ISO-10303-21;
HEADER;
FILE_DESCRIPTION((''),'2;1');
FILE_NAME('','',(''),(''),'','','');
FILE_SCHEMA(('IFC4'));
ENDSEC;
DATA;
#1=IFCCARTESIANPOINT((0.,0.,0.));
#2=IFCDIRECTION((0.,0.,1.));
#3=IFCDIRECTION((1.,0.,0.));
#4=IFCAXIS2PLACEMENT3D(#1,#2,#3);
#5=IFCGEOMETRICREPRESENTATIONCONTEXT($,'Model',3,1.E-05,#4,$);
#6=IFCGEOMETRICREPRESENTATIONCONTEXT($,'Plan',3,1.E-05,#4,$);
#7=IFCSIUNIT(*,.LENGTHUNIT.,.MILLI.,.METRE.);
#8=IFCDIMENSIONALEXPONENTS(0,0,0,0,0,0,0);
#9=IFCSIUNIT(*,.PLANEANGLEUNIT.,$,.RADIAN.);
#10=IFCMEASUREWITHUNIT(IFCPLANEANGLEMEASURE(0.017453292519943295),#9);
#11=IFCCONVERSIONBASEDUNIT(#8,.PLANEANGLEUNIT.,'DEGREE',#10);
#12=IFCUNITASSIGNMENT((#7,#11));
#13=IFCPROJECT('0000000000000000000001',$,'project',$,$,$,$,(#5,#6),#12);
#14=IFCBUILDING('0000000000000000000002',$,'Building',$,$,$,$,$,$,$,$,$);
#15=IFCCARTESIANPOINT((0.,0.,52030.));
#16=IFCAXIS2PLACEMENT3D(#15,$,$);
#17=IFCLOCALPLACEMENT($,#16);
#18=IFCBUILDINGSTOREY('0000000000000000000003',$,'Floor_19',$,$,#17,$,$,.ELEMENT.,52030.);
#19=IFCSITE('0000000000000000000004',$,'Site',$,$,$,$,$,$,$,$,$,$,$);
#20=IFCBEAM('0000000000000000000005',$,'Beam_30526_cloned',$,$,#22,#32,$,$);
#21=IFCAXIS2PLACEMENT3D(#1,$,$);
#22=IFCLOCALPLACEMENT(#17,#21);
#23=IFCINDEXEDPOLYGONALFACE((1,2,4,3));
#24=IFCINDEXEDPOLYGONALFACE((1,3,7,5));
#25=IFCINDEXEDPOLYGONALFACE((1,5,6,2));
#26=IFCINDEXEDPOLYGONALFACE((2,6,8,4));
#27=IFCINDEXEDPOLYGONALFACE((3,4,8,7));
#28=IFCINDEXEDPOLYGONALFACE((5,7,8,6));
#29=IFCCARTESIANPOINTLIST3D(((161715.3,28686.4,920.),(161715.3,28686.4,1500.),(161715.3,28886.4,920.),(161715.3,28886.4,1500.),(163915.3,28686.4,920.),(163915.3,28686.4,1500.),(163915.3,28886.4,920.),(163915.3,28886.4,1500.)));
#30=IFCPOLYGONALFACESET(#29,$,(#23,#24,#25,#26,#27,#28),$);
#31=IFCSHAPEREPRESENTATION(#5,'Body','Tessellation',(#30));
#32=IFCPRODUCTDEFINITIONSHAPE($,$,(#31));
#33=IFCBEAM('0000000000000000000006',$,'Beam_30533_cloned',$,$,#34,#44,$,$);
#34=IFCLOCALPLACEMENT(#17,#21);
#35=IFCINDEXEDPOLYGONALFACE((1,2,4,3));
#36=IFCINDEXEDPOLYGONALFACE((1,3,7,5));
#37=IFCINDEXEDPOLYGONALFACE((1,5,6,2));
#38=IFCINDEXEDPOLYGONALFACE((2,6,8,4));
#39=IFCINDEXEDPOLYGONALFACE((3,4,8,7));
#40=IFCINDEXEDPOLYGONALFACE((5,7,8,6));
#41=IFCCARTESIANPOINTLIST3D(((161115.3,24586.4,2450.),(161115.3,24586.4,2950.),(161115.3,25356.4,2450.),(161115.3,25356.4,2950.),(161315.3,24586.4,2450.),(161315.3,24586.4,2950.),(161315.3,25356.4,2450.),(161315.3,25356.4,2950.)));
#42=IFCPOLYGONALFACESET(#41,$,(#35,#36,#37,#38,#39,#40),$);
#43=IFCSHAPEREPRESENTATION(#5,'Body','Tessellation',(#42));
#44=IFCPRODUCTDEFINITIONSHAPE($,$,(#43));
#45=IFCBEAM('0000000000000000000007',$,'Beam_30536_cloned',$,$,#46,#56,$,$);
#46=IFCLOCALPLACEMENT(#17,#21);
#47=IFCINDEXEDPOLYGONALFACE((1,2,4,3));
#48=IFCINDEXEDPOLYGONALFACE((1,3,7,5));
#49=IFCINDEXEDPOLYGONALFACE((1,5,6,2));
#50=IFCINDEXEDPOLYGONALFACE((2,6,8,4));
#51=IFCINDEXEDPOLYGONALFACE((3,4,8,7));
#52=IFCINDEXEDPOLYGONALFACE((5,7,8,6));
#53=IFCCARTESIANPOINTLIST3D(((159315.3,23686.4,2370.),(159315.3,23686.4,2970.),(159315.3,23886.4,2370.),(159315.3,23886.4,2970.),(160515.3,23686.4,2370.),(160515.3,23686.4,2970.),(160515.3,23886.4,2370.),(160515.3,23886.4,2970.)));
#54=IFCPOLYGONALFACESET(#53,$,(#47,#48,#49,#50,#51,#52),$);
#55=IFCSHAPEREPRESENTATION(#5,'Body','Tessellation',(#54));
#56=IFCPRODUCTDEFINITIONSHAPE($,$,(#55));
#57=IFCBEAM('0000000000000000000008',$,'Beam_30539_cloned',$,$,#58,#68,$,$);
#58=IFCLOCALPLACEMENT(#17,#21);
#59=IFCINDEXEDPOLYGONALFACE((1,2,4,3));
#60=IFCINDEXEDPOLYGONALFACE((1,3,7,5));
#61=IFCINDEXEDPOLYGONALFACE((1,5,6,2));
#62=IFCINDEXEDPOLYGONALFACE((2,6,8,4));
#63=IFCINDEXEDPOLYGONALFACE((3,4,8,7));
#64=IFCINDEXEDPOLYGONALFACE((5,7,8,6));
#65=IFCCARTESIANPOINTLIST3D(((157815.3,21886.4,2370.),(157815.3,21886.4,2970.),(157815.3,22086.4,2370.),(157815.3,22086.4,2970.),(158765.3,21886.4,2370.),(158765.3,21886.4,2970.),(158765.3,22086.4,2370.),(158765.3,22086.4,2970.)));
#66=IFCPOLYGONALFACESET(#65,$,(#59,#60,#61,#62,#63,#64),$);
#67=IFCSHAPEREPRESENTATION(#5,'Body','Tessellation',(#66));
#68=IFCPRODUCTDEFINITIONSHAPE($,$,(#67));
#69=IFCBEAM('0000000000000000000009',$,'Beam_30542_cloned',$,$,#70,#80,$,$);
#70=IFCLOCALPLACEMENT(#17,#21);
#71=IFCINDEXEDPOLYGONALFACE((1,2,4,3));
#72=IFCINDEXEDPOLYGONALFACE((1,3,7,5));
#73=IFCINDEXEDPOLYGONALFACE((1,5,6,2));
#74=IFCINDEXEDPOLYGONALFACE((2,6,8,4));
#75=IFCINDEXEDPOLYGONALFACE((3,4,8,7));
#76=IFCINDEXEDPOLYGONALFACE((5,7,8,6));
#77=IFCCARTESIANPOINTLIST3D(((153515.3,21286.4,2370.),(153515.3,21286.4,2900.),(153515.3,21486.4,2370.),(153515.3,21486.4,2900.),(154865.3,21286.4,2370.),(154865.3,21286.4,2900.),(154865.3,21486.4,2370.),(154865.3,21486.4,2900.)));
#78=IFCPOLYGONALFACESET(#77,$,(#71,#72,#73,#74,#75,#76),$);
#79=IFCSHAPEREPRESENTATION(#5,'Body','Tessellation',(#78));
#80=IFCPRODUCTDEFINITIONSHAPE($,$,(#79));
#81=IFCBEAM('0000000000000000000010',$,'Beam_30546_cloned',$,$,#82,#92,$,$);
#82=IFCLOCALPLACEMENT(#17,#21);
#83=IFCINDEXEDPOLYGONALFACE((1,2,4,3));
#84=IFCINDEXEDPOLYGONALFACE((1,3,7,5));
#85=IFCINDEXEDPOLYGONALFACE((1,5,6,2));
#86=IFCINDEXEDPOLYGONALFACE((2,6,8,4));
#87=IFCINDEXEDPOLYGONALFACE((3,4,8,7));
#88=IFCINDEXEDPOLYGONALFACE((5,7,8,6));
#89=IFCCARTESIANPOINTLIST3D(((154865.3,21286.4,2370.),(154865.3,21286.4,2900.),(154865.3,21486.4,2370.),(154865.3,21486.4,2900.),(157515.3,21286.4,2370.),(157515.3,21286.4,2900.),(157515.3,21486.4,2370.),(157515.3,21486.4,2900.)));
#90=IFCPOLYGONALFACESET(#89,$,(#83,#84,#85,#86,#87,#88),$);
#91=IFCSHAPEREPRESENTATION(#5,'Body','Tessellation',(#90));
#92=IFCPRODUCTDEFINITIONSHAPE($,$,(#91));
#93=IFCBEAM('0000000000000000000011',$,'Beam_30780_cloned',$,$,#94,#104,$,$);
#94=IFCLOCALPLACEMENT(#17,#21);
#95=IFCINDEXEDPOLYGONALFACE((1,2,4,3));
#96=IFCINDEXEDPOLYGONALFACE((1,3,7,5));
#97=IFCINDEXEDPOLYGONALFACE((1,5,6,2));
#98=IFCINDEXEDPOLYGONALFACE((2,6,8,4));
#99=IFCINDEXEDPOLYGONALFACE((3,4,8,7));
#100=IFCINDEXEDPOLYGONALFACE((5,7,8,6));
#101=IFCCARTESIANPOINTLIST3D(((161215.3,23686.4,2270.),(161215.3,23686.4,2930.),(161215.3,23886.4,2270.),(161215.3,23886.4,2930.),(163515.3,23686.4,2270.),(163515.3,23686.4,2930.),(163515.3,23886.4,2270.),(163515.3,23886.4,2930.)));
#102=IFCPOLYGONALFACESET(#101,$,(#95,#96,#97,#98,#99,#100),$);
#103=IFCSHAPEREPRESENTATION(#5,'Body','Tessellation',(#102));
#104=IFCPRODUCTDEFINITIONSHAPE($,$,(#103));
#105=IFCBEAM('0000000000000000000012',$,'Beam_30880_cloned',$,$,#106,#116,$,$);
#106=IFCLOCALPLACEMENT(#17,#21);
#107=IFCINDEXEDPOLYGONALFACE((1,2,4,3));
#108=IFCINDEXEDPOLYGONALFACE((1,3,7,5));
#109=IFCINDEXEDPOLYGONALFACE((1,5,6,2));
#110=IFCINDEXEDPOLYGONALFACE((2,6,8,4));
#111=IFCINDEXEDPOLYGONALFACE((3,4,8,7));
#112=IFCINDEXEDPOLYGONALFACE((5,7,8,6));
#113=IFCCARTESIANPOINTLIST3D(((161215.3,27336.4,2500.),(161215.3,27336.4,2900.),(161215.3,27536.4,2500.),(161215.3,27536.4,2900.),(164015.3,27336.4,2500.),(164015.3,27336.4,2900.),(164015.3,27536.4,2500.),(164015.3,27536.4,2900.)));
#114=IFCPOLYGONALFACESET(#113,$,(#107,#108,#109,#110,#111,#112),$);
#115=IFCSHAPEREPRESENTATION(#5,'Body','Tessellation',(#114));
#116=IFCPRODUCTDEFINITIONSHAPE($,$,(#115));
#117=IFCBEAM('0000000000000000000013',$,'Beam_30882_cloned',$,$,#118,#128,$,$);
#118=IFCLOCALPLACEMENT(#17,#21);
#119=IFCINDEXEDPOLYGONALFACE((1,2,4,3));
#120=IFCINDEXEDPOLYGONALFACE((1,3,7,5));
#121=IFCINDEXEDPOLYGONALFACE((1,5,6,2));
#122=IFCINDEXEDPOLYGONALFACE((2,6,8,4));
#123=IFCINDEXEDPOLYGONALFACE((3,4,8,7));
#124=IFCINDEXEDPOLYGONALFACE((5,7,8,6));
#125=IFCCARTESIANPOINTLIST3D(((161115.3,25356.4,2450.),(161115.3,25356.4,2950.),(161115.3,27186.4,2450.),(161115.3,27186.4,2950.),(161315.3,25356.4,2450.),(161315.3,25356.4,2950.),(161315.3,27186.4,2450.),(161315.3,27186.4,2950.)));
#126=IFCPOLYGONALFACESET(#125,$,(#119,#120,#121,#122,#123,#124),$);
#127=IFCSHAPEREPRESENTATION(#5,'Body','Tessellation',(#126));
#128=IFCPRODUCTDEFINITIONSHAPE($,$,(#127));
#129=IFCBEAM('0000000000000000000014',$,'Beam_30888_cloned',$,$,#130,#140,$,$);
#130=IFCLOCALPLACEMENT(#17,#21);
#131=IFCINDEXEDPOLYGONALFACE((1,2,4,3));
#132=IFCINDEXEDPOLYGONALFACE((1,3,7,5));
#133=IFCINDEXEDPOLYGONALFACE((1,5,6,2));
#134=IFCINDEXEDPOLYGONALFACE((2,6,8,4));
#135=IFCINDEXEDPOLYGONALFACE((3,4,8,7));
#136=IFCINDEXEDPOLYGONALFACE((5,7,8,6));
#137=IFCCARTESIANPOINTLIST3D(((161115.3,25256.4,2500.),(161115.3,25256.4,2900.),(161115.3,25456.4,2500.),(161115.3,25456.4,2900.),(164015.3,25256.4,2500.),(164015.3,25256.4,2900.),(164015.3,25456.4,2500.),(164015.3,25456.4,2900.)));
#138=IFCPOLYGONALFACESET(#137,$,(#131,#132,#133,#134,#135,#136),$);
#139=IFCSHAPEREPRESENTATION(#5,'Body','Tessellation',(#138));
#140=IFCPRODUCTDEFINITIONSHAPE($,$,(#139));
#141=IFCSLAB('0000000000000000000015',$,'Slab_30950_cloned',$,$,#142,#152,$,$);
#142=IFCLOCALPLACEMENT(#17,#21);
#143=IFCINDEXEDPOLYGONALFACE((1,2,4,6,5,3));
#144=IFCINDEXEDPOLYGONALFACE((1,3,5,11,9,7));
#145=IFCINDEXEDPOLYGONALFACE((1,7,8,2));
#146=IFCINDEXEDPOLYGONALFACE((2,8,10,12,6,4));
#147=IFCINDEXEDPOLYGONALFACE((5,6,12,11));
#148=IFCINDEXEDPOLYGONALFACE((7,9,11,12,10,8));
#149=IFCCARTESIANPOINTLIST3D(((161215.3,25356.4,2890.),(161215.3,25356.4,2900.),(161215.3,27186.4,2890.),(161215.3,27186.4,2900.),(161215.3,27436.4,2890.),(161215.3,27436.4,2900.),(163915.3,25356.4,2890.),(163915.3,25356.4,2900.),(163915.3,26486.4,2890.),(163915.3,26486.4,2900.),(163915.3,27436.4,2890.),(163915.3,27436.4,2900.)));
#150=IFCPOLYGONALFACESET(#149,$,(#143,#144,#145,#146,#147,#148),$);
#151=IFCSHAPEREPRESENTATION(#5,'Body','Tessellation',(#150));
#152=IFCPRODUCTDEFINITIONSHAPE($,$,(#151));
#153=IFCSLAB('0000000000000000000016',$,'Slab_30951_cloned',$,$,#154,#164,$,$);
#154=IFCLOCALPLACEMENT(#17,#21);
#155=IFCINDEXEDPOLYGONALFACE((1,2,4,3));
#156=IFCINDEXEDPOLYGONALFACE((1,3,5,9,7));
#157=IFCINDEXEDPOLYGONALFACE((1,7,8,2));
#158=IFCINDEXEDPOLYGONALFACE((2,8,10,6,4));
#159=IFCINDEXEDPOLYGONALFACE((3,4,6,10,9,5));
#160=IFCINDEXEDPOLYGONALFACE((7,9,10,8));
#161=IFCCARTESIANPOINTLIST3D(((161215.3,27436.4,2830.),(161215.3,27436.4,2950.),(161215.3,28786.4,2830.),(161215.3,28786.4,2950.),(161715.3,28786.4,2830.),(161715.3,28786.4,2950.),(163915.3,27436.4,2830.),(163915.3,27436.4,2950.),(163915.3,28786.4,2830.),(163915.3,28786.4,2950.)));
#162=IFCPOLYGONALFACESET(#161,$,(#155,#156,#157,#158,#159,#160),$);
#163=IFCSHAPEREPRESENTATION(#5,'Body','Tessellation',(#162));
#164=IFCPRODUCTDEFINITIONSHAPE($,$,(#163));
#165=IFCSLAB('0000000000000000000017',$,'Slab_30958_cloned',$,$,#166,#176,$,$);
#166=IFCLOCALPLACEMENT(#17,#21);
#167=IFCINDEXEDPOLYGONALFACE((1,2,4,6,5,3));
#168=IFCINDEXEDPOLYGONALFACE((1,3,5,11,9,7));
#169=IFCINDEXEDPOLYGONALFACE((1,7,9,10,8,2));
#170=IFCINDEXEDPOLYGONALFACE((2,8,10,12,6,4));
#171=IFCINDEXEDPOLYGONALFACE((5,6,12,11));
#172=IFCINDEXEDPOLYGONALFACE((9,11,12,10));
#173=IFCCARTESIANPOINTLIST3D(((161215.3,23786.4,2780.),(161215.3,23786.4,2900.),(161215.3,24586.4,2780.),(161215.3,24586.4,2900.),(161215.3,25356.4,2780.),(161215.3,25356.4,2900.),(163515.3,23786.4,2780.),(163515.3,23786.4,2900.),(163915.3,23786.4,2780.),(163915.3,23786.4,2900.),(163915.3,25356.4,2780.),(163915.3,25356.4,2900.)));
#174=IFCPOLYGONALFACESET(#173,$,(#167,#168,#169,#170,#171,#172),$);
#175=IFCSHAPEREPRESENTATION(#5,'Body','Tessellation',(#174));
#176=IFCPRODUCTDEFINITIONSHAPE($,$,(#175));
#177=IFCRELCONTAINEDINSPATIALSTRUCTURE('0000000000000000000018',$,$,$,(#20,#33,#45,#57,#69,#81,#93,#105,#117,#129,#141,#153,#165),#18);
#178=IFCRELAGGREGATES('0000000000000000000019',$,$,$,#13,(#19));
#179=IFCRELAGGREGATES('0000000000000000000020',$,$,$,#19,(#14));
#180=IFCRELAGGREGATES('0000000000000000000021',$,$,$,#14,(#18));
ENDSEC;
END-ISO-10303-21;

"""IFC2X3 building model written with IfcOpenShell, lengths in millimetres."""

from ifc_helpers import new_model, entity, si_unit, converted_unit, frame, origin_with_axes, origin_2d, place, context, project, spatial, polyline, rectangle, outline, extrude, source, transform, mapped, element, save


model = new_model("IFC2X3")

# Units and contexts
model_context = context("Model", 3, precision=1e-05, world=origin_with_axes())
plan_context = context("Plan", 3, precision=1e-05, world=origin_with_axes())
ifc_project = project(units=[si_unit("LENGTHUNIT", "METRE", prefix="MILLI"), converted_unit("PLANEANGLEUNIT", "DEGREE", entity("IfcPlaneAngleMeasure", 0.017453292519943295), si_unit("PLANEANGLEUNIT", "RADIAN"), dimensions=[0, 0, 0, 0, 0, 0, 0])], contexts=[model_context, plan_context])

# Site, building, storey
site = spatial("IfcSite", under=ifc_project, Name="Site")
building = spatial("IfcBuilding", under=site, Name="Building")
storey_placement = place(None, frame((0.0, 0.0, 52030.0)))
storey = spatial("IfcBuildingStorey", under=building, at=storey_placement, Name="Floor_19", CompositionType="ELEMENT", Elevation=52030.0)

# Beams
shared_shape_1 = source(origin_with_axes(), model_context, "Body", "SweptSolid", [
    extrude(rectangle(XDim=200.0, YDim=580.0, at=origin_2d()), origin_with_axes(), (0.0, 0.0, 1.0), 2200.0),
])
beam_1_placement = place(storey_placement, frame((161715.3, 28786.4, 1210.0), z_axis=(2200.0, 0.0, 0.0), x_axis=(0.0, -2200.0, 0.0)))
element("IfcBeam", 1, at=beam_1_placement, inside=storey, Name="Beam_30526_cloned", context=model_context, shape_type="MappedRepresentation", body=[
    mapped(shared_shape_1, transform((0.0, 0.0, 0.0), x_axis=(1.0, 0.0, 0.0), y_axis=(0.0, 1.0, 0.0), z_axis=(0.0, 0.0, 1.0), scale=1.0)),
])
shared_shape_2 = source(origin_with_axes(), model_context, "Body", "SweptSolid", [
    extrude(rectangle(XDim=200.0, YDim=500.0, at=origin_2d()), origin_with_axes(), (0.0, 0.0, 1.0), 770.0),
])
beam_2_placement = place(storey_placement, frame((161215.3, 24586.4, 2700.0), z_axis=(-0.00002, 769.999996, 0.0), x_axis=(769.999996, 0.00002, 0.0)))
element("IfcBeam", 2, at=beam_2_placement, inside=storey, Name="Beam_30533_cloned", context=model_context, shape_type="MappedRepresentation", body=[
    mapped(shared_shape_2, transform((0.0, 0.0, 0.0), x_axis=(1.0, 0.0, 0.0), y_axis=(0.0, 1.0, 0.0), z_axis=(0.0, 0.0, 1.0), scale=1.0)),
])
shared_shape_3 = source(origin_with_axes(), model_context, "Body", "SweptSolid", [
    extrude(rectangle(XDim=200.0, YDim=600.0, at=origin_2d()), origin_with_axes(), (0.0, 0.0, 1.0), 1200.0),
])
beam_3_placement = place(storey_placement, frame((159315.3, 23786.4, 2670.0), z_axis=(1200.0, 0.0, 0.0), x_axis=(0.0, -1200.0, 0.0)))
element("IfcBeam", 3, at=beam_3_placement, inside=storey, Name="Beam_30536_cloned", context=model_context, shape_type="MappedRepresentation", body=[
    mapped(shared_shape_3, transform((0.0, 0.0, 0.0), x_axis=(1.0, 0.0, 0.0), y_axis=(0.0, 1.0, 0.0), z_axis=(0.0, 0.0, 1.0), scale=1.0)),
])
shared_shape_4 = source(origin_with_axes(), model_context, "Body", "SweptSolid", [
    extrude(rectangle(XDim=200.0, YDim=600.0, at=origin_2d()), origin_with_axes(), (0.0, 0.0, 1.0), 950.0),
])
beam_4_placement = place(storey_placement, frame((157815.3, 21986.4, 2670.0), z_axis=(950.0, 0.0, 0.0), x_axis=(0.0, -950.0, 0.0)))
element("IfcBeam", 4, at=beam_4_placement, inside=storey, Name="Beam_30539_cloned", context=model_context, shape_type="MappedRepresentation", body=[
    mapped(shared_shape_4, transform((0.0, 0.0, 0.0), x_axis=(1.0, 0.0, 0.0), y_axis=(0.0, 1.0, 0.0), z_axis=(0.0, 0.0, 1.0), scale=1.0)),
])
shared_shape_5 = source(origin_with_axes(), model_context, "Body", "SweptSolid", [
    extrude(rectangle(XDim=200.0, YDim=530.0, at=origin_2d()), origin_with_axes(), (0.0, 0.0, 1.0), 1350.0),
])
beam_5_placement = place(storey_placement, frame((153515.3, 21386.4, 2635.0), z_axis=(1350.0, 0.0, 0.0), x_axis=(0.0, -1350.0, 0.0)))
element("IfcBeam", 5, at=beam_5_placement, inside=storey, Name="Beam_30542_cloned", context=model_context, shape_type="MappedRepresentation", body=[
    mapped(shared_shape_5, transform((0.0, 0.0, 0.0), x_axis=(1.0, 0.0, 0.0), y_axis=(0.0, 1.0, 0.0), z_axis=(0.0, 0.0, 1.0), scale=1.0)),
])
shared_shape_6 = source(origin_with_axes(), model_context, "Body", "SweptSolid", [
    extrude(rectangle(XDim=200.0, YDim=530.0, at=origin_2d()), origin_with_axes(), (0.0, 0.0, 1.0), 2650.0),
])
beam_6_placement = place(storey_placement, frame((154865.3, 21386.4, 2635.0), z_axis=(2650.0, 0.0, 0.0), x_axis=(0.0, -2650.0, 0.0)))
element("IfcBeam", 6, at=beam_6_placement, inside=storey, Name="Beam_30546_cloned", context=model_context, shape_type="MappedRepresentation", body=[
    mapped(shared_shape_6, transform((0.0, 0.0, 0.0), x_axis=(1.0, 0.0, 0.0), y_axis=(0.0, 1.0, 0.0), z_axis=(0.0, 0.0, 1.0), scale=1.0)),
])
shared_shape_7 = source(origin_with_axes(), model_context, "Body", "SweptSolid", [
    extrude(rectangle(XDim=200.0, YDim=660.0, at=origin_2d()), origin_with_axes(), (0.0, 0.0, 1.0), 2300.0),
])
beam_7_placement = place(storey_placement, frame((161215.3, 23786.4, 2600.0), z_axis=(2299.999999, 0.0, 0.0), x_axis=(0.0, -2299.999999, 0.0)))
element("IfcBeam", 7, at=beam_7_placement, inside=storey, Name="Beam_30780_cloned", context=model_context, shape_type="MappedRepresentation", body=[
    mapped(shared_shape_7, transform((0.0, 0.0, 0.0), x_axis=(1.0, 0.0, 0.0), y_axis=(0.0, 1.0, 0.0), z_axis=(0.0, 0.0, 1.0), scale=1.0)),
])
shared_shape_8 = source(origin_with_axes(), model_context, "Body", "SweptSolid", [
    extrude(rectangle(XDim=200.0, YDim=400.0, at=origin_2d()), origin_with_axes(), (0.0, 0.0, 1.0), 2800.0),
])
beam_8_placement = place(storey_placement, frame((161215.3, 27436.4, 2700.0), z_axis=(2800.00002, 0.0, 0.0), x_axis=(0.0, -2800.00002, 0.0)))
element("IfcBeam", 8, at=beam_8_placement, inside=storey, Name="Beam_30880_cloned", context=model_context, shape_type="MappedRepresentation", body=[
    mapped(shared_shape_8, transform((0.0, 0.0, 0.0), x_axis=(1.0, 0.0, 0.0), y_axis=(0.0, 1.0, 0.0), z_axis=(0.0, 0.0, 1.0), scale=1.0)),
])
shared_shape_9 = source(origin_with_axes(), model_context, "Body", "SweptSolid", [
    extrude(rectangle(XDim=200.0, YDim=500.0, at=origin_2d()), origin_with_axes(), (0.0, 0.0, 1.0), 1830.0),
])
beam_9_placement = place(storey_placement, frame((161215.3, 25356.4, 2700.0), z_axis=(0.0, 1830.000006, 0.0), x_axis=(1830.000006, 0.0, 0.0)))
element("IfcBeam", 9, at=beam_9_placement, inside=storey, Name="Beam_30882_cloned", context=model_context, shape_type="MappedRepresentation", body=[
    mapped(shared_shape_9, transform((0.0, 0.0, 0.0), x_axis=(1.0, 0.0, 0.0), y_axis=(0.0, 1.0, 0.0), z_axis=(0.0, 0.0, 1.0), scale=1.0)),
])
shared_shape_10 = source(origin_with_axes(), model_context, "Body", "SweptSolid", [
    extrude(rectangle(XDim=200.0, YDim=400.0, at=origin_2d()), origin_with_axes(), (0.0, 0.0, 1.0), 2900.0),
])
beam_10_placement = place(storey_placement, frame((161115.3, 25356.4, 2700.0), z_axis=(2900.00002, 0.0, 0.0), x_axis=(0.0, -2900.00002, 0.0)))
element("IfcBeam", 10, at=beam_10_placement, inside=storey, Name="Beam_30888_cloned", context=model_context, shape_type="MappedRepresentation", body=[
    mapped(shared_shape_10, transform((0.0, 0.0, 0.0), x_axis=(1.0, 0.0, 0.0), y_axis=(0.0, 1.0, 0.0), z_axis=(0.0, 0.0, 1.0), scale=1.0)),
])

# Slabs
shared_shape_11 = source(origin_with_axes(), model_context, "Body", "SweptSolid", [
    extrude(outline(polyline([(0.0, 0.0), (250.0, 0.0), (2080.0, 0.0), (2080.0, 2700.0), (950.0, 2700.0), (0.0, 2700.0)])), origin_with_axes(), (0.0, 0.0, 1.0), 10.0),
])
slab_1_placement = place(storey_placement, frame((161215.3, 27436.4, 2890.0), z_axis=(0.0, 0.0, 1.0), x_axis=(0.0, -250.0, 0.0)))
element("IfcSlab", 11, at=slab_1_placement, inside=storey, Name="Slab_30950_cloned", context=model_context, shape_type="MappedRepresentation", body=[
    mapped(shared_shape_11, transform((0.0, 0.0, 0.0), x_axis=(1.0, 0.0, 0.0), y_axis=(0.0, 1.0, 0.0), z_axis=(0.0, 0.0, 1.0), scale=1.0)),
])
shared_shape_12 = source(origin_with_axes(), model_context, "Body", "SweptSolid", [
    extrude(outline(polyline([(0.0, 0.0), (1350.0, 0.0), (1350.0, 2700.0), (0.0, 2700.0), (0.0, 500.0)])), origin_with_axes(), (0.0, 0.0, 1.0), 120.0),
])
slab_2_placement = place(storey_placement, frame((161215.3, 28786.4, 2830.0), z_axis=(0.0, 0.0, 1.0), x_axis=(0.0, -1350.0, 0.0)))
element("IfcSlab", 12, at=slab_2_placement, inside=storey, Name="Slab_30951_cloned", context=model_context, shape_type="MappedRepresentation", body=[
    mapped(shared_shape_12, transform((0.0, 0.0, 0.0), x_axis=(1.0, 0.0, 0.0), y_axis=(0.0, 1.0, 0.0), z_axis=(0.0, 0.0, 1.0), scale=1.0)),
])
shared_shape_13 = source(origin_with_axes(), model_context, "Body", "SweptSolid", [
    extrude(outline(polyline([(0.0, 0.0), (770.0, 0.0), (1570.0, 0.0), (1570.0, 2300.0), (1570.0, 2700.0), (0.0, 2700.0)])), origin_with_axes(), (0.0, 0.0, 1.0), 120.0),
])
slab_3_placement = place(storey_placement, frame((161215.3, 25356.4, 2780.0), z_axis=(0.0, 0.0, 1.0), x_axis=(0.0, -770.0, 0.0)))
element("IfcSlab", 13, at=slab_3_placement, inside=storey, Name="Slab_30958_cloned", context=model_context, shape_type="MappedRepresentation", body=[
    mapped(shared_shape_13, transform((0.0, 0.0, 0.0), x_axis=(1.0, 0.0, 0.0), y_axis=(0.0, 1.0, 0.0), z_axis=(0.0, 0.0, 1.0), scale=1.0)),
])

save(model, "model.ifc")
